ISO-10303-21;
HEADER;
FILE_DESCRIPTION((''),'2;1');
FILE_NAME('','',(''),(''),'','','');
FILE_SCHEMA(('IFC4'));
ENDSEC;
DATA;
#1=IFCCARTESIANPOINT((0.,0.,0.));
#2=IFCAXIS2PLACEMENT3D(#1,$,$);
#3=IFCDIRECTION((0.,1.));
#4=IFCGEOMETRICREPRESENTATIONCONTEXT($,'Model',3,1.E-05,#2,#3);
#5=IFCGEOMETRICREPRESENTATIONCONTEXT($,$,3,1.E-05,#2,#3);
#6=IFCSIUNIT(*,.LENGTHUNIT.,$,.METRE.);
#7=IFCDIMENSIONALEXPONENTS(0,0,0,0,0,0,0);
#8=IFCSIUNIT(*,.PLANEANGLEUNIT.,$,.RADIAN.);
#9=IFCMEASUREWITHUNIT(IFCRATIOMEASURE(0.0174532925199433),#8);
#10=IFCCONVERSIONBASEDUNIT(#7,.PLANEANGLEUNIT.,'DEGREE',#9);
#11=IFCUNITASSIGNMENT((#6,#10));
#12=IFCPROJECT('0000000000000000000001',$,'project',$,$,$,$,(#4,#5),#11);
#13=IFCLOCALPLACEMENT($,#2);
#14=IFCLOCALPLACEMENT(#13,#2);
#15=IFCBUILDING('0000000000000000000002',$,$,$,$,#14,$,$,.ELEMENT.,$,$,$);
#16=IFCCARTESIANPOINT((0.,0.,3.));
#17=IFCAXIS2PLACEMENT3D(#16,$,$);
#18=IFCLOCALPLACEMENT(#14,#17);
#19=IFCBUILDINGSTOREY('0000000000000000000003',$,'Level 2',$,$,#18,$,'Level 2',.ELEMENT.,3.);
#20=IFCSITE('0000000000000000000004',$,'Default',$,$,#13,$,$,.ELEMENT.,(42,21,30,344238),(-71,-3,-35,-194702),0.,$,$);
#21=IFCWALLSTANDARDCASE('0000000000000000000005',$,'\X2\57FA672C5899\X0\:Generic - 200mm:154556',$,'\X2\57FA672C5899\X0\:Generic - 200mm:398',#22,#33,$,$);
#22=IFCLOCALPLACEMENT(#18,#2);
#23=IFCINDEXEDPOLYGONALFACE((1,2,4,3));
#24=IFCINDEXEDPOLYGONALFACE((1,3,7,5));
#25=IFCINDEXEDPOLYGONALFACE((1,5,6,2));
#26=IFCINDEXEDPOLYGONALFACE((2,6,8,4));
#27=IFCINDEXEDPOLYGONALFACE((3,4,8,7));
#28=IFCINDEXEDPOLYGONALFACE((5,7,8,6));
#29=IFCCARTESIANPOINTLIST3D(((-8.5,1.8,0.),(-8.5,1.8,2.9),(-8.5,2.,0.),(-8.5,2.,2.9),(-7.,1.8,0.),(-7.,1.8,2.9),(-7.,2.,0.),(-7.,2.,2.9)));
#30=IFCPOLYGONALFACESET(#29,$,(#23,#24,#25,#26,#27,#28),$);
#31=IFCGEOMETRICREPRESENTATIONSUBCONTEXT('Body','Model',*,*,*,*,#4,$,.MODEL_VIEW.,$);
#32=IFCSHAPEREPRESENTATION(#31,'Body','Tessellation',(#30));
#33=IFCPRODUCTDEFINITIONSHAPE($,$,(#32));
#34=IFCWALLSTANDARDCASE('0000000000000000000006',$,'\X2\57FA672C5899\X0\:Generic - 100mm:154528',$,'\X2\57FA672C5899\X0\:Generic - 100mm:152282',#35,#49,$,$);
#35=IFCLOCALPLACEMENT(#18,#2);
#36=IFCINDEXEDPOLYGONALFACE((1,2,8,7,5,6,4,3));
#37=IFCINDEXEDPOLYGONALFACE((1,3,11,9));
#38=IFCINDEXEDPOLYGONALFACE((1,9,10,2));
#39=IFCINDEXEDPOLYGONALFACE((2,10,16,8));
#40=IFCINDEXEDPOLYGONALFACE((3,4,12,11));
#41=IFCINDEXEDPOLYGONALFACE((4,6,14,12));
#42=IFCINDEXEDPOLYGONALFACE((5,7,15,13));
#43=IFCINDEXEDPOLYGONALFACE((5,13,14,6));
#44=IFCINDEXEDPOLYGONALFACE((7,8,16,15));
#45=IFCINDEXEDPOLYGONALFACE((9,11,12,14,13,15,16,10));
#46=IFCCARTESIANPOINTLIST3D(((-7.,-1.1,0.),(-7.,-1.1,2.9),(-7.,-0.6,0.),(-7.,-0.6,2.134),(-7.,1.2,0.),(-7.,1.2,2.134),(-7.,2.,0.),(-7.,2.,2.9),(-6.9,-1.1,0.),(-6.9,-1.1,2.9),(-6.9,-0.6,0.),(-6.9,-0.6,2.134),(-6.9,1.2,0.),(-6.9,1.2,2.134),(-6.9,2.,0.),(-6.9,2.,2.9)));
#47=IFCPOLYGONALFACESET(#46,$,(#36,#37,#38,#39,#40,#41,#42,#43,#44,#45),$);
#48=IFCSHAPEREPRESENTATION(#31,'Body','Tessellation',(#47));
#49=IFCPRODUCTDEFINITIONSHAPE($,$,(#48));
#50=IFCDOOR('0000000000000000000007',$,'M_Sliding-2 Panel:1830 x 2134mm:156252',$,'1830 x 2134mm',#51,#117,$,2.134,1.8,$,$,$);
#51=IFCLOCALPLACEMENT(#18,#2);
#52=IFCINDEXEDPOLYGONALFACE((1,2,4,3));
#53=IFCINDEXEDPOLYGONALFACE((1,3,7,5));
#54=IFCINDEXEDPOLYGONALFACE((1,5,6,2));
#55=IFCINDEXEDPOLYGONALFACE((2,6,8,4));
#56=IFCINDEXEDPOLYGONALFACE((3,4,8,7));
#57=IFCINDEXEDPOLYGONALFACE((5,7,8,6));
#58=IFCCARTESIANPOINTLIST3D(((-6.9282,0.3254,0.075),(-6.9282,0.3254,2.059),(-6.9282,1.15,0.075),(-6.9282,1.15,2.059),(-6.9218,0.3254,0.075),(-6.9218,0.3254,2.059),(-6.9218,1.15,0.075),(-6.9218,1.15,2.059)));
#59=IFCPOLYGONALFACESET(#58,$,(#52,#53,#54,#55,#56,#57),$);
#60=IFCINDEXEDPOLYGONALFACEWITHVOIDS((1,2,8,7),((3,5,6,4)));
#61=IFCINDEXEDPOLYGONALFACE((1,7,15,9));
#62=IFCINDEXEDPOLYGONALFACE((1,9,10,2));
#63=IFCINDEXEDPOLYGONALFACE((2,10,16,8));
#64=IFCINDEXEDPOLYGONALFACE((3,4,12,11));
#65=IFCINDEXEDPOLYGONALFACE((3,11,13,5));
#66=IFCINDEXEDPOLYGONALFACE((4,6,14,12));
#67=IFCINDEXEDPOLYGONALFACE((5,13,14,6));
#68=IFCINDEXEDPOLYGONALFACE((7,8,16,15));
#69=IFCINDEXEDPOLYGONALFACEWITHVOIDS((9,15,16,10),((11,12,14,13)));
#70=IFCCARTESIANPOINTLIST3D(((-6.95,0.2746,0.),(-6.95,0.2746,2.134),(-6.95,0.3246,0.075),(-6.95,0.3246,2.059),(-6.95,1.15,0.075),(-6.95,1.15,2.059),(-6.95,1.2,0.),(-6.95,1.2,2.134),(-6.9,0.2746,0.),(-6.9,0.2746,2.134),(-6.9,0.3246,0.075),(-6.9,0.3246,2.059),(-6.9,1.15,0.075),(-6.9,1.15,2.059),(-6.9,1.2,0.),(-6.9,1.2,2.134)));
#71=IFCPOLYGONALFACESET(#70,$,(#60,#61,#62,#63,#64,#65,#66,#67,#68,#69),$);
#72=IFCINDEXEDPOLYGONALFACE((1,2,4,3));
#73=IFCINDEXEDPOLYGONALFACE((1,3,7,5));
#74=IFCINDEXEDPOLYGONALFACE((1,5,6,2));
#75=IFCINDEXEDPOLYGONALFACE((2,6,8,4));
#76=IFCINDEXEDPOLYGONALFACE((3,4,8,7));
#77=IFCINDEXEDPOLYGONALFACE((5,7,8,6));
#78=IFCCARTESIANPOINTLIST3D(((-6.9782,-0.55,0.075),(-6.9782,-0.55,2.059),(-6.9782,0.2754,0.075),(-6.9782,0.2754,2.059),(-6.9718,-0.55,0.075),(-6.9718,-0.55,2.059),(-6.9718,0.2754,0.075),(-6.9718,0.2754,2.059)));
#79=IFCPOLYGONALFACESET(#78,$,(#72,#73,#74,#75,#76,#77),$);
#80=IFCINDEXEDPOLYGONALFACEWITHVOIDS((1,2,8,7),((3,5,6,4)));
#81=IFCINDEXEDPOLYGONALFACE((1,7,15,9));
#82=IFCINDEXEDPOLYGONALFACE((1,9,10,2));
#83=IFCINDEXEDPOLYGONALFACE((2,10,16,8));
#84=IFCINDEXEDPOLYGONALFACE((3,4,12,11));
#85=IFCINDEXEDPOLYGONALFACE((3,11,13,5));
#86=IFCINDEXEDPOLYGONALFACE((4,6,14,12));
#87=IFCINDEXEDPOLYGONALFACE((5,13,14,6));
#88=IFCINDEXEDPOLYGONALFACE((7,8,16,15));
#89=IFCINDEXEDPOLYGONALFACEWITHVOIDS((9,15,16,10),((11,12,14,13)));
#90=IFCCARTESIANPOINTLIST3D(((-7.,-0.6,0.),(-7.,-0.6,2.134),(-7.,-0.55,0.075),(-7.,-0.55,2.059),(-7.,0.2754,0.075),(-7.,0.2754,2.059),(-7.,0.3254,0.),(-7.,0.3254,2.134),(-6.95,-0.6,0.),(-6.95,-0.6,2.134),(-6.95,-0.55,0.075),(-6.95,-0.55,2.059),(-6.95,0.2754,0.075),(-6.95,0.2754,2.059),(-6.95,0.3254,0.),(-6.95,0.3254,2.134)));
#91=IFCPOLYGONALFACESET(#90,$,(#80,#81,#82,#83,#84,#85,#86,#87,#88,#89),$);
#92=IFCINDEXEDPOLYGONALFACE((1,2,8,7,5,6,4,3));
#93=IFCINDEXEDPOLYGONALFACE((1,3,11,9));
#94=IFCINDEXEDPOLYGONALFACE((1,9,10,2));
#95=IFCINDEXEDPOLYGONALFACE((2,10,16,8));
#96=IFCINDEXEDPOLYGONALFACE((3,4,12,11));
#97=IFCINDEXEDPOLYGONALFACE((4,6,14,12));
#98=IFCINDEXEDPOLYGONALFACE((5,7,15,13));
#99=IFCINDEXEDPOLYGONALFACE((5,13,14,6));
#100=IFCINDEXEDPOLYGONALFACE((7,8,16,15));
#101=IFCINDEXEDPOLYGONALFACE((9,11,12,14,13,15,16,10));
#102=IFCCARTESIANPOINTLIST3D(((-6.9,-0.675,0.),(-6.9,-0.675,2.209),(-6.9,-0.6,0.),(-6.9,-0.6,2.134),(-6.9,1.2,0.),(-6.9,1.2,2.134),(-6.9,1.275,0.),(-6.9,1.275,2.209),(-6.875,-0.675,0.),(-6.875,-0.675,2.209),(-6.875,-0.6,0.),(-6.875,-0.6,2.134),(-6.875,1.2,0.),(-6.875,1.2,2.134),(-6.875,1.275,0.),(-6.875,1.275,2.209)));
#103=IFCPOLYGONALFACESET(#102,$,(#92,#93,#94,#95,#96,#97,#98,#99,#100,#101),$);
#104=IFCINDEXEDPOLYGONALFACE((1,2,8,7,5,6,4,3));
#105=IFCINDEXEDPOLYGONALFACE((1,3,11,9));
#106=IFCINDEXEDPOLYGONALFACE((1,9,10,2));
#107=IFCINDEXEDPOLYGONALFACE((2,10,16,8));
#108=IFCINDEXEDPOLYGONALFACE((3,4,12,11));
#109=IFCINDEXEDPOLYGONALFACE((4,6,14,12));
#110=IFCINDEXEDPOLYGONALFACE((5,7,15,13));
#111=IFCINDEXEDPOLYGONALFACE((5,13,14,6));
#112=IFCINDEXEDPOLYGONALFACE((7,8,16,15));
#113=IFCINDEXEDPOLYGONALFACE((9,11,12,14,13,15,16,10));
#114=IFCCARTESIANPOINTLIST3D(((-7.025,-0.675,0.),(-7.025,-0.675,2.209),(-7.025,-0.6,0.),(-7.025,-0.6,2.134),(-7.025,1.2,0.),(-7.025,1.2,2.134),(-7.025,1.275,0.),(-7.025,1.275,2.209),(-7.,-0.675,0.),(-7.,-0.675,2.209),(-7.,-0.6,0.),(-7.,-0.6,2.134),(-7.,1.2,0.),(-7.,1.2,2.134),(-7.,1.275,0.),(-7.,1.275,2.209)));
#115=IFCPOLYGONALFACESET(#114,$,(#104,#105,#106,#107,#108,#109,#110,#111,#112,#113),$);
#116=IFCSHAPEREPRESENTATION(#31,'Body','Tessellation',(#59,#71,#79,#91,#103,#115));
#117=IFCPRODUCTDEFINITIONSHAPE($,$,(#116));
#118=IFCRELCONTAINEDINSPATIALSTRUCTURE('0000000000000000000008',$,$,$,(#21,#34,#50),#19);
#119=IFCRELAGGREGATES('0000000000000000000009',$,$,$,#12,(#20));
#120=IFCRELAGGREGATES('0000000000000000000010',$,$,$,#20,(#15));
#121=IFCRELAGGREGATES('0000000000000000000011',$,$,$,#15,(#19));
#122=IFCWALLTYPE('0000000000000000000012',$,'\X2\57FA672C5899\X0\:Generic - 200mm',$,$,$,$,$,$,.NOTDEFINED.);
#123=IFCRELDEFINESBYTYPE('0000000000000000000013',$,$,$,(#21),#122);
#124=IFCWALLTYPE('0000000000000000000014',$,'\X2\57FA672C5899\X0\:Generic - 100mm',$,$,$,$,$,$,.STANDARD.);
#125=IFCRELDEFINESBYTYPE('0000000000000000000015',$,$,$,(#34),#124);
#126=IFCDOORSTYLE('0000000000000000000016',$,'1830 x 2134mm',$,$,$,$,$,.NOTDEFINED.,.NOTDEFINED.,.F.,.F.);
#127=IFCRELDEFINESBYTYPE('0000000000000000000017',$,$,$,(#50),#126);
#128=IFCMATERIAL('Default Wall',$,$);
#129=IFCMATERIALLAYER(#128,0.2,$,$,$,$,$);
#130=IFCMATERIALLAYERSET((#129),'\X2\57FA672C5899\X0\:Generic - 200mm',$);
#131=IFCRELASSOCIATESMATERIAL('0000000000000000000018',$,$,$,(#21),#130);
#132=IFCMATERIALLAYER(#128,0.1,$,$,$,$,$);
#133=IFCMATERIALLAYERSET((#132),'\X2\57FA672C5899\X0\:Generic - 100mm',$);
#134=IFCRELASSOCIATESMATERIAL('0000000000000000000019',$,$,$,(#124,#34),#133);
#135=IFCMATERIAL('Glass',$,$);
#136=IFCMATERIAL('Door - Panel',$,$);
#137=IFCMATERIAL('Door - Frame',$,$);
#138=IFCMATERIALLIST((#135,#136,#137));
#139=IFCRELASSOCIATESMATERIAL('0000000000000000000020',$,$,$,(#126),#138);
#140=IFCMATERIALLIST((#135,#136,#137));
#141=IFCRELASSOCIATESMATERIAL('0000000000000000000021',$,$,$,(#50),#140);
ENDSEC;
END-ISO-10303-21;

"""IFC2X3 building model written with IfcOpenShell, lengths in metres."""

from ifc_helpers import new_model, entity, si_unit, converted_unit, direction, frame, frame_2d, origin, origin_2d_with_axis, place, context, subcontext, project, spatial, polyline, rectangle, outline, extrude, clip, bounded_halfspace, source, transform, mapped, material, material_list, layer, layer_set, layer_usage, type_object, type_shapes, element, fill, save


model = new_model("IFC2X3")

# Units and contexts
model_context = context("Model", 3, precision=1e-05, world=origin(), true_north=direction((0.0, 1.0)))
context_of_model = context(None, 3, precision=1e-05, world=origin(), true_north=direction((0.0, 1.0)))
body_context = subcontext(model_context, "Body", "Model", "MODEL_VIEW")
ifc_project = project(units=[si_unit("LENGTHUNIT", "METRE"), converted_unit("PLANEANGLEUNIT", "DEGREE", entity("IfcRatioMeasure", 0.0174532925199433), si_unit("PLANEANGLEUNIT", "RADIAN"), dimensions=[0, 0, 0, 0, 0, 0, 0])], contexts=[model_context, context_of_model])

# Site, building, storey
site_placement = place(None, origin())
site = spatial("IfcSite", under=ifc_project, at=site_placement, Name="Default", CompositionType="ELEMENT", RefLatitude=(42, 21, 30, 344238), RefLongitude=(-71, -3, -35, -194702), RefElevation=0.0)
building_placement = place(site_placement, origin())
building = spatial("IfcBuilding", under=site, at=building_placement, CompositionType="ELEMENT")
storey_placement = place(building_placement, frame((0.0, 0.0, 3.0)))
storey = spatial("IfcBuildingStorey", under=building, at=storey_placement, Name="Level 2", LongName="Level 2", CompositionType="ELEMENT", Elevation=3.0)

# Shared definitions
ifc_material_1 = material(Name="Default Wall")
ifc_layer_1 = layer(ifc_material_1, 0.2)
ifc_layer_set_1 = layer_set([ifc_layer_1], Name="基本墙:Generic - 200mm")
wall_type_1 = type_object("IfcWallType", Name="基本墙:Generic - 200mm", PredefinedType="NOTDEFINED")
ifc_material_2 = material(Name="Glass")

# Wall
ifc_layer_usage_1 = layer_usage(ifc_layer_set_1, "AXIS2", "NEGATIVE", 0.1)
wall_1_placement = place(storey_placement, frame((-7.0, 1.9, 0.0), z_axis=(0.0, 0.0, 1.0), x_axis=(-1.0, 0.0, 0.0)))
element("IfcWallStandardCase", 1, at=wall_1_placement, inside=storey, type_object=wall_type_1, material=ifc_layer_usage_1, Name="基本墙:Generic - 200mm:154556", ObjectType="基本墙:Generic - 200mm:398", context=body_context, shape_type="Clipping", body=[
    clip(extrude(rectangle(XDim=1.5, YDim=0.2, at=frame_2d((0.75, 0.0), x_axis=(-1.0, 0.0))), origin(), (0.0, 0.0, 1.0), 3.2), bounded_halfspace(frame((0.0, -0.1, 2.9), z_axis=(0.0, 0.0, -1.0), x_axis=(0.0, 1.0, 0.0)), True, frame((0.0, -0.1, 2.9), z_axis=(0.0, 0.0, -1.0), x_axis=(0.0, 1.0, 0.0)), polyline([(0.0, 0.0), (0.2, 0.0), (0.2, 1.5), (0.0, 1.5), (0.0, 0.0)]))),
])

# Wall, opening, door
ifc_layer_2 = layer(ifc_material_1, 0.1)
ifc_layer_set_2 = layer_set([ifc_layer_2], Name="基本墙:Generic - 100mm")
ifc_layer_usage_2 = layer_usage(ifc_layer_set_2, "AXIS2", "NEGATIVE", 0.05)
wall_type_2 = type_object("IfcWallType", Name="基本墙:Generic - 100mm", PredefinedType="STANDARD", material=ifc_layer_set_2)
wall_2_placement = place(storey_placement, frame((-6.95, -1.1, 0.0), z_axis=(0.0, 0.0, 1.0), x_axis=(0.0, 1.0, 0.0)))
wall_2 = element("IfcWallStandardCase", 2, at=wall_2_placement, inside=storey, type_object=wall_type_2, material=ifc_layer_usage_2, Name="基本墙:Generic - 100mm:154528", ObjectType="基本墙:Generic - 100mm:152282", context=body_context, shape_type="Clipping", body=[
    clip(extrude(rectangle(XDim=3.1, YDim=0.1, at=frame_2d((1.55, 0.0), x_axis=(-1.0, 0.0))), origin(), (0.0, 0.0, 1.0), 3.2), bounded_halfspace(frame((0.0, -0.05, 2.9), z_axis=(0.0, 0.0, -1.0), x_axis=(-1.0, 0.0, 0.0)), True, frame((0.0, -0.05, 2.9), z_axis=(0.0, 0.0, -1.0), x_axis=(-1.0, 0.0, 0.0)), polyline([(0.0, 0.0), (0.0, 0.1), (-2.9, 0.1), (-3.1, 0.1), (-3.1, 0.0), (-3.0, 0.0), (0.0, 0.0)]))),
])
opening_1_placement = place(wall_2_placement, frame((0.5, -0.05, 0.0)))
opening_1 = element("IfcOpeningElement", 3, at=opening_1_placement, cuts=wall_2, ObjectType="Opening", context=body_context, shape_type="SweptSolid", body=[
    extrude(rectangle(XDim=2.134, YDim=1.8, at=frame_2d((1.067, 0.9), x_axis=(-1.0, 0.0))), frame((0.0, 0.0, 0.0), z_axis=(0.0, 1.0, 0.0), x_axis=(0.0, 0.0, 1.0)), (0.0, 0.0, 1.0), 0.1),
])
ifc_material_3 = material(Name="Door - Panel")
ifc_material_4 = material(Name="Door - Frame")
ifc_material_list_1 = material_list([ifc_material_2, ifc_material_3, ifc_material_4])
ifc_material_list_2 = material_list([ifc_material_2, ifc_material_3, ifc_material_4])
door_style_1 = type_object("IfcDoorStyle", Name="1830 x 2134mm", ConstructionType="NOTDEFINED", OperationType="NOTDEFINED", ParameterTakesPrecedence=False, Sizeable=False, material=ifc_material_list_2)
shared_shape_1 = source(origin(), body_context, "Body", "SweptSolid", [
    extrude(rectangle(XDim=0.0063, YDim=0.8246, at=origin_2d_with_axis()), frame((1.3377, 0.025, 0.075), z_axis=(0.0, 0.0, 1.0), x_axis=(0.0, -1.0, 0.0)), (0.0, 0.0, 1.0), 1.984),
    extrude(outline(polyline([(-0.4627, -1.067), (0.4627, -1.067), (0.4627, 1.067), (-0.4627, 1.067), (-0.4627, -1.067)]), holes=[polyline([(-0.4127, -0.992), (-0.4127, 0.992), (0.4127, 0.992), (0.4127, -0.992), (-0.4127, -0.992)])]), frame((1.3373, 0.0, 1.067), z_axis=(0.0, 1.0, 0.0), x_axis=(1.0, 0.0, 0.0)), (0.0, 0.0, 1.0), 0.05),
    extrude(rectangle(XDim=0.0063, YDim=0.8254, at=frame_2d((0.0, 0.0), x_axis=(1.0, 0.0))), frame((0.4627, 0.075, 0.075), z_axis=(0.0, 0.0, 1.0), x_axis=(0.0, -1.0, 0.0)), (0.0, 0.0, 1.0), 1.984),
    extrude(outline(polyline([(-1.067, -0.4627), (1.067, -0.4627), (1.067, 0.4627), (-1.067, 0.4627), (-1.067, -0.4627)]), holes=[polyline([(-0.992, -0.4127), (-0.992, 0.4127), (0.992, 0.4127), (0.992, -0.4127), (-0.992, -0.4127)])]), frame((0.4627, 0.05, 1.067), z_axis=(0.0, 1.0, 0.0), x_axis=(0.0, 0.0, -1.0)), (0.0, 0.0, 1.0), 0.05),
    extrude(outline(polyline([(-1.0857, -0.975), (1.1233, -0.975), (1.1233, 0.975), (-1.0857, 0.975), (-1.0857, 0.9), (1.0482, 0.9), (1.0482, -0.9), (-1.0857, -0.9), (-1.0857, -0.975)])), frame((0.9, -0.025, 1.0857), z_axis=(0.0, 1.0, 0.0), x_axis=(0.0, 0.0, 1.0)), (0.0, 0.0, 1.0), 0.025),
    extrude(outline(polyline([(-0.975, -1.0857), (-0.9, -1.0857), (-0.9, 1.0482), (0.9, 1.0482), (0.9, -1.0857), (0.975, -1.0857), (0.975, 1.1233), (-0.975, 1.1233), (-0.975, -1.0857)])), frame((0.9, 0.1, 1.0857), z_axis=(0.0, 1.0, 0.0), x_axis=(-1.0, 0.0, 0.0)), (0.0, 0.0, 1.0), 0.025),
])
type_shapes(door_style_1, [shared_shape_1])
door_1_placement = place(opening_1_placement, origin())
door_1 = element("IfcDoor", 4, at=door_1_placement, inside=storey, type_object=door_style_1, material=ifc_material_list_1, Name="M_Sliding-2 Panel:1830 x 2134mm:156252", ObjectType="1830 x 2134mm", OverallHeight=2.134, OverallWidth=1.8, context=body_context, shape_type="MappedRepresentation", body=[
    mapped(shared_shape_1, transform((0.0, 0.0, 0.0), scale=1.0)),
])
fill(opening_1, door_1)

save(model, "model.ifc")
